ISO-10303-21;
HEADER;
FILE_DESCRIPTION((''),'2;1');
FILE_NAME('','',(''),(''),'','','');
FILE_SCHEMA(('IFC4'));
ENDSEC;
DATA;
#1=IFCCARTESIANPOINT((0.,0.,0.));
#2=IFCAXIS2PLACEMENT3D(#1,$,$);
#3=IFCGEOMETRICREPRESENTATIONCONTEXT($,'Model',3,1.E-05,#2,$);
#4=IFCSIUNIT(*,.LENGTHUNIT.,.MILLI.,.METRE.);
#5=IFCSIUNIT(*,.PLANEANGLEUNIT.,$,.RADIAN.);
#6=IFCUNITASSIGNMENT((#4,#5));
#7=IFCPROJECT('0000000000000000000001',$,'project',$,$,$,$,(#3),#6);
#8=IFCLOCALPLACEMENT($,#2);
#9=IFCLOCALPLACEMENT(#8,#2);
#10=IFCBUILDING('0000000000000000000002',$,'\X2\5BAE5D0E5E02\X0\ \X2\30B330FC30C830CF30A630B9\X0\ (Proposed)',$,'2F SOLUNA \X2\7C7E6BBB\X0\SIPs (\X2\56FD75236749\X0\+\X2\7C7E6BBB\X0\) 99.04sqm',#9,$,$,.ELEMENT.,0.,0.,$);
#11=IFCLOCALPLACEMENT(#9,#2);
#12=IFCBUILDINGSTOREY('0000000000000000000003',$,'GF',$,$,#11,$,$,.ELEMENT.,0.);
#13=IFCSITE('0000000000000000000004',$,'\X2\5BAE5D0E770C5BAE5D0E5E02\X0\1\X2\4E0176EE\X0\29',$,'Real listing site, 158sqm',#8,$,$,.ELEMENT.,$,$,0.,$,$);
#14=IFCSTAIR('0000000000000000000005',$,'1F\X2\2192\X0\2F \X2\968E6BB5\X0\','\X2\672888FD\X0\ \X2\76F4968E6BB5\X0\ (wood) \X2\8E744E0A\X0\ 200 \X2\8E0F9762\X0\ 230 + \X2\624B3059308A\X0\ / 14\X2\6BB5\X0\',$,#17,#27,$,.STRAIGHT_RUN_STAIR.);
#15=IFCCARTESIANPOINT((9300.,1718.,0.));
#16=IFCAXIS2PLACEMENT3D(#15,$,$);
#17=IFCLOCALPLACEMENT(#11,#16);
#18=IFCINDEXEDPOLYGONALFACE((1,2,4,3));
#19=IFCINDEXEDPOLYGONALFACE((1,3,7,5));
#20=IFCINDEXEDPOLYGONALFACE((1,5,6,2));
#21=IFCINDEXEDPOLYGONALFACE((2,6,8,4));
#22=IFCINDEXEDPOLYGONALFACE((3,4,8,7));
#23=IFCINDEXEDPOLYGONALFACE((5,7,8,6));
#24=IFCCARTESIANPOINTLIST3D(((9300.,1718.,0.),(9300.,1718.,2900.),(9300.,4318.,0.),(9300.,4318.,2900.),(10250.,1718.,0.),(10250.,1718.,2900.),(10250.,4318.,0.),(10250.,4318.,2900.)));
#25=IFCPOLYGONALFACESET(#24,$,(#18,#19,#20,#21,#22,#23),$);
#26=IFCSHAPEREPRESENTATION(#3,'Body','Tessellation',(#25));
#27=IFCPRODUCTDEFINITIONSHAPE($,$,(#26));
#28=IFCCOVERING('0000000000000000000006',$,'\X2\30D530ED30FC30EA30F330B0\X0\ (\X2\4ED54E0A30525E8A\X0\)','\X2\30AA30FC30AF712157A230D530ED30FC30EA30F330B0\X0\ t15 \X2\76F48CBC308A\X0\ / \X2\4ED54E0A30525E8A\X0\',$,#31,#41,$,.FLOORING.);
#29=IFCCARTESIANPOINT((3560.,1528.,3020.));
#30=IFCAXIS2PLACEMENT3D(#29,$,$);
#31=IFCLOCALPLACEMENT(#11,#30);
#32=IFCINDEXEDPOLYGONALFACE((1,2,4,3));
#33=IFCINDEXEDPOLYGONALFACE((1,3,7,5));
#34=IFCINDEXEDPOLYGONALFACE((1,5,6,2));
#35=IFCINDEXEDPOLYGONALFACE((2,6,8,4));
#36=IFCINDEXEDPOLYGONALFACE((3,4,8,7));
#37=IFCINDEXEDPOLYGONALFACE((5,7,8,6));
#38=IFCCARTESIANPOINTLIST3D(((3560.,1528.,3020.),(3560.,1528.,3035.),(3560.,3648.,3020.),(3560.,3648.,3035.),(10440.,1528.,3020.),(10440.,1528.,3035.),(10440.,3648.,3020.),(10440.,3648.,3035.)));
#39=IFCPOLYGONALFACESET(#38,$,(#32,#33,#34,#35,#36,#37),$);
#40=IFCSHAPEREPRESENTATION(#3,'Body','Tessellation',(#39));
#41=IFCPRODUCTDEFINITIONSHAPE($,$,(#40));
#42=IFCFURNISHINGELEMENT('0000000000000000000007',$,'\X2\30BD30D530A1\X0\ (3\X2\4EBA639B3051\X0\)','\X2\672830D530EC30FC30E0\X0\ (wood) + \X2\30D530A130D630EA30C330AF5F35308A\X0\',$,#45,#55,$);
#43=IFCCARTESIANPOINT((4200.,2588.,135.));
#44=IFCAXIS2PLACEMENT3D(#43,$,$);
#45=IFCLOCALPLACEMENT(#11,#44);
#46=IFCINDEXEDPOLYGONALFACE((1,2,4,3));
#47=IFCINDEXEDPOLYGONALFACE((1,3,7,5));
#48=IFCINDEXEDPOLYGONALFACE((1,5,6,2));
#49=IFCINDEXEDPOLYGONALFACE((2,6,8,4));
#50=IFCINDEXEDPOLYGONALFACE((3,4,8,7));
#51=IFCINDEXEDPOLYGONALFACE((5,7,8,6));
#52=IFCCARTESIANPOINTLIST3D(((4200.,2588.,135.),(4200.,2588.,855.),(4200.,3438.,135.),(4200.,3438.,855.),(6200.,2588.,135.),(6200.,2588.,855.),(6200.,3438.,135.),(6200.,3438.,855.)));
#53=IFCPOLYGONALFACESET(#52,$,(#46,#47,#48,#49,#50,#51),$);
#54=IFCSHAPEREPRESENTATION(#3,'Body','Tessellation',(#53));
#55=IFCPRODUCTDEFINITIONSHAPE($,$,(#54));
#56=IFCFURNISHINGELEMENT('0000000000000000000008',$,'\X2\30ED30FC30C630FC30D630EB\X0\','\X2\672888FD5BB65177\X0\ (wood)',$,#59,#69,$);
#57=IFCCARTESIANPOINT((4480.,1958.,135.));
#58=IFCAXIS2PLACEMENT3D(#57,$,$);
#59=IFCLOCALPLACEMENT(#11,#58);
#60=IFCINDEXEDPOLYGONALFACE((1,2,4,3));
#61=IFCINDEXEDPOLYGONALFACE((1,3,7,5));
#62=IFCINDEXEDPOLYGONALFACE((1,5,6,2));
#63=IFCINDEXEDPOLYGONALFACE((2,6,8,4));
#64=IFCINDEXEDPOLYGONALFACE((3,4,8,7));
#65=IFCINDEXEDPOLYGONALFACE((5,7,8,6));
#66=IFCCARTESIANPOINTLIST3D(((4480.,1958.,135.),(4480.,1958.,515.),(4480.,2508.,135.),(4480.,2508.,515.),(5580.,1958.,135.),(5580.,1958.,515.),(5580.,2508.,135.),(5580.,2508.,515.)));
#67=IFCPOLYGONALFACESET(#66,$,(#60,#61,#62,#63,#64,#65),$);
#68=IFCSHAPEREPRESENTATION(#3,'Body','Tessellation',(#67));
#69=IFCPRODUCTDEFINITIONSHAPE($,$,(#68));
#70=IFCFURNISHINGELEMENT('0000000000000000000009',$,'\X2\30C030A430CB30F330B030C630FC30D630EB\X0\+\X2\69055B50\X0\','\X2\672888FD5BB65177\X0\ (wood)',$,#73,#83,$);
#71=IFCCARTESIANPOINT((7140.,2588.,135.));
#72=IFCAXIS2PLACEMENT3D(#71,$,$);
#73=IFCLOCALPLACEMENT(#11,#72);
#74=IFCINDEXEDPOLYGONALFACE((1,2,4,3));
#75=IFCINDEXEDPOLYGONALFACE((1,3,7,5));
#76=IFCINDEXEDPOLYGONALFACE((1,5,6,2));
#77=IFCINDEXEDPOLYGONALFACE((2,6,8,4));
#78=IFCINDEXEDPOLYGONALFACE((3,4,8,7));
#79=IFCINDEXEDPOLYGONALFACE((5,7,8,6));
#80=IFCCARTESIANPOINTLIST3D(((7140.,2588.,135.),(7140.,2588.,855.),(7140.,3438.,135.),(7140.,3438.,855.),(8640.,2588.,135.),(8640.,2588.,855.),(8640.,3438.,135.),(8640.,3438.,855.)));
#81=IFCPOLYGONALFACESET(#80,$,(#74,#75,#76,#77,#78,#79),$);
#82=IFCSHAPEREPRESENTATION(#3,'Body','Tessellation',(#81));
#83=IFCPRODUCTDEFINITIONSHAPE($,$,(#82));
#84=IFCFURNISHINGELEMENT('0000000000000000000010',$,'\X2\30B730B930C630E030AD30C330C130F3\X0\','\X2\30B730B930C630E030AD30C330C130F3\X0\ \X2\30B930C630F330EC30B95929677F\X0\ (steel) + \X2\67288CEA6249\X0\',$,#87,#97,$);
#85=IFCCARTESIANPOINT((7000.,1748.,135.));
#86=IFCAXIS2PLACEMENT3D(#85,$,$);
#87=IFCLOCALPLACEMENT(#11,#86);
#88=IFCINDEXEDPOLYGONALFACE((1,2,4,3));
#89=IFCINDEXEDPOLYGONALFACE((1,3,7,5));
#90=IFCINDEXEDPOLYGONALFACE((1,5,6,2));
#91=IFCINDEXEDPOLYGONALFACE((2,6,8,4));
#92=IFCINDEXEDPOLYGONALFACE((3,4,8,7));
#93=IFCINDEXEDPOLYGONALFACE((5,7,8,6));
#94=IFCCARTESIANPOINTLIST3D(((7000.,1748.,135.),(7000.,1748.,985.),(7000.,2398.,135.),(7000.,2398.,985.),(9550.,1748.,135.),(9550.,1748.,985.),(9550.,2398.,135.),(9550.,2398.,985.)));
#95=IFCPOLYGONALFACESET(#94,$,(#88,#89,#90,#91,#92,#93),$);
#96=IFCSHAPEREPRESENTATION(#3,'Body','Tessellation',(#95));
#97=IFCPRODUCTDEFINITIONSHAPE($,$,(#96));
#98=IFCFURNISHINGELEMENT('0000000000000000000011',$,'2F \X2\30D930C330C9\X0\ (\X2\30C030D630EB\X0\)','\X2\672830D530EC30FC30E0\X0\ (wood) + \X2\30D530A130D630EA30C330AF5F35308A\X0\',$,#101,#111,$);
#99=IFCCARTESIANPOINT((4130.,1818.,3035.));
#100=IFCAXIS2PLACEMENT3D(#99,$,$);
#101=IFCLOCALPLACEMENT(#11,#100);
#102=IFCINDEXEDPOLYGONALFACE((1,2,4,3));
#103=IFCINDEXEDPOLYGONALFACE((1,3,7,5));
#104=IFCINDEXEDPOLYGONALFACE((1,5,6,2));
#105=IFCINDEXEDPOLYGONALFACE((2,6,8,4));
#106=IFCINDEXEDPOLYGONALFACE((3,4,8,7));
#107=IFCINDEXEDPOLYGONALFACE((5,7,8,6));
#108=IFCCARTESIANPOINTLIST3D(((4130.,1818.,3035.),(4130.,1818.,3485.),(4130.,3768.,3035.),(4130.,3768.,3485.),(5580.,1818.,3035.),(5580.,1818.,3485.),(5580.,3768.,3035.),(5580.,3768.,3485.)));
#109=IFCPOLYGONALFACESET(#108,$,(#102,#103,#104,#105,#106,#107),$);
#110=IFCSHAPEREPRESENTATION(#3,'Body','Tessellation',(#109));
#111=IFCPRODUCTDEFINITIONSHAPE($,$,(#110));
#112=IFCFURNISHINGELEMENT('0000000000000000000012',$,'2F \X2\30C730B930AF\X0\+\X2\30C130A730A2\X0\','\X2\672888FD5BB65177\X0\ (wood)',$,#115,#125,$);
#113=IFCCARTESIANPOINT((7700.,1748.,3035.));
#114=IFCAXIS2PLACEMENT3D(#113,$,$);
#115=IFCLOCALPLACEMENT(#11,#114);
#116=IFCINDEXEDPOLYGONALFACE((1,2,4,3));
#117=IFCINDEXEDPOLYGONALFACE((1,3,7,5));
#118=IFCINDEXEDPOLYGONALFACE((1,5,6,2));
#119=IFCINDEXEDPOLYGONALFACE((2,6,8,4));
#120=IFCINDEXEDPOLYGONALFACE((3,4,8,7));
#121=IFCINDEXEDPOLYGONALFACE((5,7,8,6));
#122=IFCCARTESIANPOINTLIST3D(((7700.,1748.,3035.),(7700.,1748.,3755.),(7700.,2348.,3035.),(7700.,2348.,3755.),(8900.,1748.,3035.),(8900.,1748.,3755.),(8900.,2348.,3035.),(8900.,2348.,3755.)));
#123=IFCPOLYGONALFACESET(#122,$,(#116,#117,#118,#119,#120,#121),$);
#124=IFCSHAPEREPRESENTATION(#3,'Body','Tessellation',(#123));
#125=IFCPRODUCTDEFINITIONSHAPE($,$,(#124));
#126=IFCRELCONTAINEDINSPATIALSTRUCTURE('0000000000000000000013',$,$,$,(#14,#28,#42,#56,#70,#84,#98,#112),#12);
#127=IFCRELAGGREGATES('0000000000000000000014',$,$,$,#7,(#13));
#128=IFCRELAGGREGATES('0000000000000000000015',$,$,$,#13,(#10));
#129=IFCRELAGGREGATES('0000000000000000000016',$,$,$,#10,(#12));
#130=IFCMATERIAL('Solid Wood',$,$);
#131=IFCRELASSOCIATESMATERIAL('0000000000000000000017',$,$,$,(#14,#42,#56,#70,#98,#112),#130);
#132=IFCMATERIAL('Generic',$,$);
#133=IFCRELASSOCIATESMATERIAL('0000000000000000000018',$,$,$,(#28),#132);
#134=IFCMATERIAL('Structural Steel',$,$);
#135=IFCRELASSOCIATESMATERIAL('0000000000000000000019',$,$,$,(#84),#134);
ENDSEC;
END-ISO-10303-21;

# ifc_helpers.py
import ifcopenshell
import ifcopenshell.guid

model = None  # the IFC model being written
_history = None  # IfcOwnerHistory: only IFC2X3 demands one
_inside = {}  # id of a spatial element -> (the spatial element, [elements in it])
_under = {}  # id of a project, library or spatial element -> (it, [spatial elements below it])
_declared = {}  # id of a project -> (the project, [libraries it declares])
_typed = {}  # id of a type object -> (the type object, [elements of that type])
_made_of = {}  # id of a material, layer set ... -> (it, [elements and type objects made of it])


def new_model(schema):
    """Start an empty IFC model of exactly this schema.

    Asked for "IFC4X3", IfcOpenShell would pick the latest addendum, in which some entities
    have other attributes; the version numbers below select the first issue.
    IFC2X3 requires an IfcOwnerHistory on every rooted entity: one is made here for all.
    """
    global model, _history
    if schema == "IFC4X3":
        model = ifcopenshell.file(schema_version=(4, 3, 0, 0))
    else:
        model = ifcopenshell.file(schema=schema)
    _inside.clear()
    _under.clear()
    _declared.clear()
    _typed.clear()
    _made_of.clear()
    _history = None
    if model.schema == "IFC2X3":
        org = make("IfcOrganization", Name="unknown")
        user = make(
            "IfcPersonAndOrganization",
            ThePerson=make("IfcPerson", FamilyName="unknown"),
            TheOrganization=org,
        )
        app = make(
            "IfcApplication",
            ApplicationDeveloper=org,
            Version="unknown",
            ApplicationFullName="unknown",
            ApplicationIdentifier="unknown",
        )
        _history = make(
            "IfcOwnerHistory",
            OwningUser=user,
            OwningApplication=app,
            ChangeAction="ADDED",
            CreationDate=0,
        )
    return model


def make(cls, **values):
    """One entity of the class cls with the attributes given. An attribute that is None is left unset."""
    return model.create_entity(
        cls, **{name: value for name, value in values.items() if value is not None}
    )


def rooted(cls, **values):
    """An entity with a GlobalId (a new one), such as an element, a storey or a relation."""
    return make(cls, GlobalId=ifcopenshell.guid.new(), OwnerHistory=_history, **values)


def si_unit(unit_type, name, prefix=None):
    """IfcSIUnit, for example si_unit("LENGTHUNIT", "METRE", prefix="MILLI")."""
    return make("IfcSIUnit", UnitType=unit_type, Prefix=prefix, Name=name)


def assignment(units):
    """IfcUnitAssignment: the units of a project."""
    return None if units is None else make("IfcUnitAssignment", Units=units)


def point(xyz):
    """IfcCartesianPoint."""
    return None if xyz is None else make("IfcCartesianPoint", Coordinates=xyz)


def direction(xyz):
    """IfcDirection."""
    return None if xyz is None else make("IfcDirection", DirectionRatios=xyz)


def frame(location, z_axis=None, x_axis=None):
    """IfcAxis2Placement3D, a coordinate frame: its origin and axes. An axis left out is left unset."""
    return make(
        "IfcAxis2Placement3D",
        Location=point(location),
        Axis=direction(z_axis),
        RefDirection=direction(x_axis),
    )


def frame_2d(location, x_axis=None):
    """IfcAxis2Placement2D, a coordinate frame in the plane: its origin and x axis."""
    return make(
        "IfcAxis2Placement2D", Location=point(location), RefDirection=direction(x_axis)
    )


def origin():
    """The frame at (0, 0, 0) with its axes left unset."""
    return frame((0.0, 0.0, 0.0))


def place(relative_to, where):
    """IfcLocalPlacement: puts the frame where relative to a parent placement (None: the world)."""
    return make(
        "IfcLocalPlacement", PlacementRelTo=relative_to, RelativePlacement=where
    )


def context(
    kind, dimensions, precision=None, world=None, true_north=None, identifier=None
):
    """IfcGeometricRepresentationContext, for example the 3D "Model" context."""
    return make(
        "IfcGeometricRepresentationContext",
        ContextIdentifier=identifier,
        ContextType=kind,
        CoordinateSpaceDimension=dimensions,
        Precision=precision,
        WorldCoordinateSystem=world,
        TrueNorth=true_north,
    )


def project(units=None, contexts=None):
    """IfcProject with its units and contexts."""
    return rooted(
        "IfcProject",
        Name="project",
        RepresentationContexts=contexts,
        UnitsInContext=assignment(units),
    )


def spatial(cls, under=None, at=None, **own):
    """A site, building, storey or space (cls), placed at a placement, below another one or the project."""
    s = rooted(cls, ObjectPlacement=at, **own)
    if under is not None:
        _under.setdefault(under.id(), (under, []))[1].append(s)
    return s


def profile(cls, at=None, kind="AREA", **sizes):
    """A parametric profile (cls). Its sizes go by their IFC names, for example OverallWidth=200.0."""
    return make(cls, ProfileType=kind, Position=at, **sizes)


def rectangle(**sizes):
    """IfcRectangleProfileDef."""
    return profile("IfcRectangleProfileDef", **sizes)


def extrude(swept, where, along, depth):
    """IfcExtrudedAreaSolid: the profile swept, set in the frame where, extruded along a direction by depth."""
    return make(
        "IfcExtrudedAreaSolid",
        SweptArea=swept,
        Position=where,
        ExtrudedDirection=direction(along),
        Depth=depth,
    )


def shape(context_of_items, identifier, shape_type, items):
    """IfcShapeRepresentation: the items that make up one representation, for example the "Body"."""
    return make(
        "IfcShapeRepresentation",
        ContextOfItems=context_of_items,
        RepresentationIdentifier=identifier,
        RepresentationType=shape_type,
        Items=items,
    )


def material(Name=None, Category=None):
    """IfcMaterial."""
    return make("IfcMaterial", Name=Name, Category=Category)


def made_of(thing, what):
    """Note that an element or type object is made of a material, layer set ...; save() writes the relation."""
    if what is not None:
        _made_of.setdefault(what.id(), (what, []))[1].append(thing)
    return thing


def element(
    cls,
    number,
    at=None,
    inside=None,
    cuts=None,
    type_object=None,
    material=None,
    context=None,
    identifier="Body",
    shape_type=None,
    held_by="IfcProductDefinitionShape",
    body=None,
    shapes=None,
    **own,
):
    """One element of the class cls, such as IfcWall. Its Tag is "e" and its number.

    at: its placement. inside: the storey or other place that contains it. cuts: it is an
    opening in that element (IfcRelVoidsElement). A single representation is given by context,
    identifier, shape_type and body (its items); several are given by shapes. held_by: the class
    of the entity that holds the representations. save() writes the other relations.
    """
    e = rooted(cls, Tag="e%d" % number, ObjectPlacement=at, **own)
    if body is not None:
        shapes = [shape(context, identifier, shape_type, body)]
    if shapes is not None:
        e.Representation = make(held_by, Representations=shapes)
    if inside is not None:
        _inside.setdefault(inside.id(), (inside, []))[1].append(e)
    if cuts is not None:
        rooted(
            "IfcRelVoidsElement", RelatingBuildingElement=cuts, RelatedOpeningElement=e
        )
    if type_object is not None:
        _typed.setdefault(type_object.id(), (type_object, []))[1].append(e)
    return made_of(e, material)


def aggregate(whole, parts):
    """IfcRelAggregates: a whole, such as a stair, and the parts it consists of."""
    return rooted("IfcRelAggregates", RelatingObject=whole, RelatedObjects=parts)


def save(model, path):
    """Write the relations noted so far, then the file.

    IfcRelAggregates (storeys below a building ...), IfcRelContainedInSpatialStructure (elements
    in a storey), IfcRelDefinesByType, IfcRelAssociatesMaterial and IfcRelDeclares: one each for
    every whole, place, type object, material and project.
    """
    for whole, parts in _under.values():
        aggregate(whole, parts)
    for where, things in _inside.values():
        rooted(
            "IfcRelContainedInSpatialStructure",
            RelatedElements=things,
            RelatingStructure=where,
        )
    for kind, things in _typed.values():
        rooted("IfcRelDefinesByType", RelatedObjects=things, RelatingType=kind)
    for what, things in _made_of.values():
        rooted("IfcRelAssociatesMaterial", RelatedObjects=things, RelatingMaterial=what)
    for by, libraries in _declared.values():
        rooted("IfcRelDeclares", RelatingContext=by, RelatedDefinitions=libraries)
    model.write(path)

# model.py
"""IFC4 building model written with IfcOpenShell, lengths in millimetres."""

from ifc_helpers import new_model, si_unit, frame, frame_2d, origin, place, context, project, spatial, rectangle, extrude, material, element, save


model = new_model("IFC4")

# Units and contexts
model_context = context("Model", 3, precision=1e-05, world=origin())
ifc_project = project(units=[si_unit("LENGTHUNIT", "METRE", prefix="MILLI"), si_unit("PLANEANGLEUNIT", "RADIAN")], contexts=[model_context])

# Site, building, storey
site_placement = place(None, origin())
site = spatial("IfcSite", under=ifc_project, at=site_placement, Name="宮崎県宮崎市1丁目29", ObjectType="Real listing site, 158sqm", CompositionType="ELEMENT", RefElevation=0.0)
building_placement = place(site_placement, origin())
building = spatial("IfcBuilding", under=site, at=building_placement, Name="宮崎市 コートハウス (Proposed)", ObjectType="2F SOLUNA 籾殻SIPs (国産杉+籾殻) 99.04sqm", CompositionType="ELEMENT", ElevationOfRefHeight=0.0, ElevationOfTerrain=0.0)
storey_placement = place(building_placement, origin())
storey = spatial("IfcBuildingStorey", under=building, at=storey_placement, Name="GF", CompositionType="ELEMENT", Elevation=0.0)

# Shared definitions
ifc_material_1 = material(Name="Solid Wood")

# Shared definitions
ifc_material_2 = material(Name="Generic")

# Stair
stair_placement = place(storey_placement, frame((9300.0, 1718.0, 0.0)))
element("IfcStair", 1, at=stair_placement, inside=storey, material=ifc_material_1, Name="1F→2F 階段", Description="木製 直階段 (wood) 蹴上 200 踏面 230 + 手すり / 14段", PredefinedType="STRAIGHT_RUN_STAIR", context=model_context, shape_type="SweptSolid", body=[
    extrude(rectangle(XDim=950.0, YDim=2600.0, at=frame_2d((475.0, 1300.0))), frame((9300.0, 1718.0, 0.0)), (0.0, 0.0, 1.0), 2900.0),
])

# Covering
covering_placement = place(storey_placement, frame((3560.0, 1528.0, 3020.0)))
element("IfcCovering", 2, at=covering_placement, inside=storey, material=ifc_material_2, Name="フローリング (仕上げ床)", Description="オーク無垢フローリング t15 直貼り / 仕上げ床", PredefinedType="FLOORING", context=model_context, shape_type="SweptSolid", body=[
    extrude(rectangle(XDim=6880.0, YDim=2120.0, at=frame_2d((3440.0, 1060.0))), frame((3560.0, 1528.0, 3020.0)), (0.0, 0.0, 1.0), 15.0),
])

# Furnishing elements
furnishing_1_placement = place(storey_placement, frame((4200.0, 2588.0, 135.0)))
element("IfcFurnishingElement", 3, at=furnishing_1_placement, inside=storey, material=ifc_material_1, Name="ソファ (3人掛け)", Description="木フレーム (wood) + ファブリック張り", context=model_context, shape_type="SweptSolid", body=[
    extrude(rectangle(XDim=2000.0, YDim=850.0, at=frame_2d((1000.0, 425.0))), frame((4200.0, 2588.0, 135.0)), (0.0, 0.0, 1.0), 720.0),
])
furnishing_2_placement = place(storey_placement, frame((4480.0, 1958.0, 135.0)))
element("IfcFurnishingElement", 4, at=furnishing_2_placement, inside=storey, material=ifc_material_1, Name="ローテーブル", Description="木製家具 (wood)", context=model_context, shape_type="SweptSolid", body=[
    extrude(rectangle(XDim=1100.0, YDim=550.0, at=frame_2d((550.0, 275.0))), frame((4480.0, 1958.0, 135.0)), (0.0, 0.0, 1.0), 380.0),
])
furnishing_3_placement = place(storey_placement, frame((7140.0, 2588.0, 135.0)))
element("IfcFurnishingElement", 5, at=furnishing_3_placement, inside=storey, material=ifc_material_1, Name="ダイニングテーブル+椅子", Description="木製家具 (wood)", context=model_context, shape_type="SweptSolid", body=[
    extrude(rectangle(XDim=1500.0, YDim=850.0, at=frame_2d((750.0, 425.0))), frame((7140.0, 2588.0, 135.0)), (0.0, 0.0, 1.0), 720.0),
])
ifc_material_3 = material(Name="Structural Steel")
furnishing_4_placement = place(storey_placement, frame((7000.0, 1748.0, 135.0)))
element("IfcFurnishingElement", 6, at=furnishing_4_placement, inside=storey, material=ifc_material_3, Name="システムキッチン", Description="システムキッチン ステンレス天板 (steel) + 木質扉", context=model_context, shape_type="SweptSolid", body=[
    extrude(rectangle(XDim=2550.0, YDim=650.0, at=frame_2d((1275.0, 325.0))), frame((7000.0, 1748.0, 135.0)), (0.0, 0.0, 1.0), 850.0),
])
furnishing_5_placement = place(storey_placement, frame((4130.0, 1818.0, 3035.0)))
element("IfcFurnishingElement", 7, at=furnishing_5_placement, inside=storey, material=ifc_material_1, Name="2F ベッド (ダブル)", Description="木フレーム (wood) + ファブリック張り", context=model_context, shape_type="SweptSolid", body=[
    extrude(rectangle(XDim=1450.0, YDim=1950.0, at=frame_2d((725.0, 975.0))), frame((4130.0, 1818.0, 3035.0)), (0.0, 0.0, 1.0), 450.0),
])
furnishing_6_placement = place(storey_placement, frame((7700.0, 1748.0, 3035.0)))
element("IfcFurnishingElement", 8, at=furnishing_6_placement, inside=storey, material=ifc_material_1, Name="2F デスク+チェア", Description="木製家具 (wood)", context=model_context, shape_type="SweptSolid", body=[
    extrude(rectangle(XDim=1200.0, YDim=600.0, at=frame_2d((600.0, 300.0))), frame((7700.0, 1748.0, 3035.0)), (0.0, 0.0, 1.0), 720.0),
])

save(model, "model.ifc")
